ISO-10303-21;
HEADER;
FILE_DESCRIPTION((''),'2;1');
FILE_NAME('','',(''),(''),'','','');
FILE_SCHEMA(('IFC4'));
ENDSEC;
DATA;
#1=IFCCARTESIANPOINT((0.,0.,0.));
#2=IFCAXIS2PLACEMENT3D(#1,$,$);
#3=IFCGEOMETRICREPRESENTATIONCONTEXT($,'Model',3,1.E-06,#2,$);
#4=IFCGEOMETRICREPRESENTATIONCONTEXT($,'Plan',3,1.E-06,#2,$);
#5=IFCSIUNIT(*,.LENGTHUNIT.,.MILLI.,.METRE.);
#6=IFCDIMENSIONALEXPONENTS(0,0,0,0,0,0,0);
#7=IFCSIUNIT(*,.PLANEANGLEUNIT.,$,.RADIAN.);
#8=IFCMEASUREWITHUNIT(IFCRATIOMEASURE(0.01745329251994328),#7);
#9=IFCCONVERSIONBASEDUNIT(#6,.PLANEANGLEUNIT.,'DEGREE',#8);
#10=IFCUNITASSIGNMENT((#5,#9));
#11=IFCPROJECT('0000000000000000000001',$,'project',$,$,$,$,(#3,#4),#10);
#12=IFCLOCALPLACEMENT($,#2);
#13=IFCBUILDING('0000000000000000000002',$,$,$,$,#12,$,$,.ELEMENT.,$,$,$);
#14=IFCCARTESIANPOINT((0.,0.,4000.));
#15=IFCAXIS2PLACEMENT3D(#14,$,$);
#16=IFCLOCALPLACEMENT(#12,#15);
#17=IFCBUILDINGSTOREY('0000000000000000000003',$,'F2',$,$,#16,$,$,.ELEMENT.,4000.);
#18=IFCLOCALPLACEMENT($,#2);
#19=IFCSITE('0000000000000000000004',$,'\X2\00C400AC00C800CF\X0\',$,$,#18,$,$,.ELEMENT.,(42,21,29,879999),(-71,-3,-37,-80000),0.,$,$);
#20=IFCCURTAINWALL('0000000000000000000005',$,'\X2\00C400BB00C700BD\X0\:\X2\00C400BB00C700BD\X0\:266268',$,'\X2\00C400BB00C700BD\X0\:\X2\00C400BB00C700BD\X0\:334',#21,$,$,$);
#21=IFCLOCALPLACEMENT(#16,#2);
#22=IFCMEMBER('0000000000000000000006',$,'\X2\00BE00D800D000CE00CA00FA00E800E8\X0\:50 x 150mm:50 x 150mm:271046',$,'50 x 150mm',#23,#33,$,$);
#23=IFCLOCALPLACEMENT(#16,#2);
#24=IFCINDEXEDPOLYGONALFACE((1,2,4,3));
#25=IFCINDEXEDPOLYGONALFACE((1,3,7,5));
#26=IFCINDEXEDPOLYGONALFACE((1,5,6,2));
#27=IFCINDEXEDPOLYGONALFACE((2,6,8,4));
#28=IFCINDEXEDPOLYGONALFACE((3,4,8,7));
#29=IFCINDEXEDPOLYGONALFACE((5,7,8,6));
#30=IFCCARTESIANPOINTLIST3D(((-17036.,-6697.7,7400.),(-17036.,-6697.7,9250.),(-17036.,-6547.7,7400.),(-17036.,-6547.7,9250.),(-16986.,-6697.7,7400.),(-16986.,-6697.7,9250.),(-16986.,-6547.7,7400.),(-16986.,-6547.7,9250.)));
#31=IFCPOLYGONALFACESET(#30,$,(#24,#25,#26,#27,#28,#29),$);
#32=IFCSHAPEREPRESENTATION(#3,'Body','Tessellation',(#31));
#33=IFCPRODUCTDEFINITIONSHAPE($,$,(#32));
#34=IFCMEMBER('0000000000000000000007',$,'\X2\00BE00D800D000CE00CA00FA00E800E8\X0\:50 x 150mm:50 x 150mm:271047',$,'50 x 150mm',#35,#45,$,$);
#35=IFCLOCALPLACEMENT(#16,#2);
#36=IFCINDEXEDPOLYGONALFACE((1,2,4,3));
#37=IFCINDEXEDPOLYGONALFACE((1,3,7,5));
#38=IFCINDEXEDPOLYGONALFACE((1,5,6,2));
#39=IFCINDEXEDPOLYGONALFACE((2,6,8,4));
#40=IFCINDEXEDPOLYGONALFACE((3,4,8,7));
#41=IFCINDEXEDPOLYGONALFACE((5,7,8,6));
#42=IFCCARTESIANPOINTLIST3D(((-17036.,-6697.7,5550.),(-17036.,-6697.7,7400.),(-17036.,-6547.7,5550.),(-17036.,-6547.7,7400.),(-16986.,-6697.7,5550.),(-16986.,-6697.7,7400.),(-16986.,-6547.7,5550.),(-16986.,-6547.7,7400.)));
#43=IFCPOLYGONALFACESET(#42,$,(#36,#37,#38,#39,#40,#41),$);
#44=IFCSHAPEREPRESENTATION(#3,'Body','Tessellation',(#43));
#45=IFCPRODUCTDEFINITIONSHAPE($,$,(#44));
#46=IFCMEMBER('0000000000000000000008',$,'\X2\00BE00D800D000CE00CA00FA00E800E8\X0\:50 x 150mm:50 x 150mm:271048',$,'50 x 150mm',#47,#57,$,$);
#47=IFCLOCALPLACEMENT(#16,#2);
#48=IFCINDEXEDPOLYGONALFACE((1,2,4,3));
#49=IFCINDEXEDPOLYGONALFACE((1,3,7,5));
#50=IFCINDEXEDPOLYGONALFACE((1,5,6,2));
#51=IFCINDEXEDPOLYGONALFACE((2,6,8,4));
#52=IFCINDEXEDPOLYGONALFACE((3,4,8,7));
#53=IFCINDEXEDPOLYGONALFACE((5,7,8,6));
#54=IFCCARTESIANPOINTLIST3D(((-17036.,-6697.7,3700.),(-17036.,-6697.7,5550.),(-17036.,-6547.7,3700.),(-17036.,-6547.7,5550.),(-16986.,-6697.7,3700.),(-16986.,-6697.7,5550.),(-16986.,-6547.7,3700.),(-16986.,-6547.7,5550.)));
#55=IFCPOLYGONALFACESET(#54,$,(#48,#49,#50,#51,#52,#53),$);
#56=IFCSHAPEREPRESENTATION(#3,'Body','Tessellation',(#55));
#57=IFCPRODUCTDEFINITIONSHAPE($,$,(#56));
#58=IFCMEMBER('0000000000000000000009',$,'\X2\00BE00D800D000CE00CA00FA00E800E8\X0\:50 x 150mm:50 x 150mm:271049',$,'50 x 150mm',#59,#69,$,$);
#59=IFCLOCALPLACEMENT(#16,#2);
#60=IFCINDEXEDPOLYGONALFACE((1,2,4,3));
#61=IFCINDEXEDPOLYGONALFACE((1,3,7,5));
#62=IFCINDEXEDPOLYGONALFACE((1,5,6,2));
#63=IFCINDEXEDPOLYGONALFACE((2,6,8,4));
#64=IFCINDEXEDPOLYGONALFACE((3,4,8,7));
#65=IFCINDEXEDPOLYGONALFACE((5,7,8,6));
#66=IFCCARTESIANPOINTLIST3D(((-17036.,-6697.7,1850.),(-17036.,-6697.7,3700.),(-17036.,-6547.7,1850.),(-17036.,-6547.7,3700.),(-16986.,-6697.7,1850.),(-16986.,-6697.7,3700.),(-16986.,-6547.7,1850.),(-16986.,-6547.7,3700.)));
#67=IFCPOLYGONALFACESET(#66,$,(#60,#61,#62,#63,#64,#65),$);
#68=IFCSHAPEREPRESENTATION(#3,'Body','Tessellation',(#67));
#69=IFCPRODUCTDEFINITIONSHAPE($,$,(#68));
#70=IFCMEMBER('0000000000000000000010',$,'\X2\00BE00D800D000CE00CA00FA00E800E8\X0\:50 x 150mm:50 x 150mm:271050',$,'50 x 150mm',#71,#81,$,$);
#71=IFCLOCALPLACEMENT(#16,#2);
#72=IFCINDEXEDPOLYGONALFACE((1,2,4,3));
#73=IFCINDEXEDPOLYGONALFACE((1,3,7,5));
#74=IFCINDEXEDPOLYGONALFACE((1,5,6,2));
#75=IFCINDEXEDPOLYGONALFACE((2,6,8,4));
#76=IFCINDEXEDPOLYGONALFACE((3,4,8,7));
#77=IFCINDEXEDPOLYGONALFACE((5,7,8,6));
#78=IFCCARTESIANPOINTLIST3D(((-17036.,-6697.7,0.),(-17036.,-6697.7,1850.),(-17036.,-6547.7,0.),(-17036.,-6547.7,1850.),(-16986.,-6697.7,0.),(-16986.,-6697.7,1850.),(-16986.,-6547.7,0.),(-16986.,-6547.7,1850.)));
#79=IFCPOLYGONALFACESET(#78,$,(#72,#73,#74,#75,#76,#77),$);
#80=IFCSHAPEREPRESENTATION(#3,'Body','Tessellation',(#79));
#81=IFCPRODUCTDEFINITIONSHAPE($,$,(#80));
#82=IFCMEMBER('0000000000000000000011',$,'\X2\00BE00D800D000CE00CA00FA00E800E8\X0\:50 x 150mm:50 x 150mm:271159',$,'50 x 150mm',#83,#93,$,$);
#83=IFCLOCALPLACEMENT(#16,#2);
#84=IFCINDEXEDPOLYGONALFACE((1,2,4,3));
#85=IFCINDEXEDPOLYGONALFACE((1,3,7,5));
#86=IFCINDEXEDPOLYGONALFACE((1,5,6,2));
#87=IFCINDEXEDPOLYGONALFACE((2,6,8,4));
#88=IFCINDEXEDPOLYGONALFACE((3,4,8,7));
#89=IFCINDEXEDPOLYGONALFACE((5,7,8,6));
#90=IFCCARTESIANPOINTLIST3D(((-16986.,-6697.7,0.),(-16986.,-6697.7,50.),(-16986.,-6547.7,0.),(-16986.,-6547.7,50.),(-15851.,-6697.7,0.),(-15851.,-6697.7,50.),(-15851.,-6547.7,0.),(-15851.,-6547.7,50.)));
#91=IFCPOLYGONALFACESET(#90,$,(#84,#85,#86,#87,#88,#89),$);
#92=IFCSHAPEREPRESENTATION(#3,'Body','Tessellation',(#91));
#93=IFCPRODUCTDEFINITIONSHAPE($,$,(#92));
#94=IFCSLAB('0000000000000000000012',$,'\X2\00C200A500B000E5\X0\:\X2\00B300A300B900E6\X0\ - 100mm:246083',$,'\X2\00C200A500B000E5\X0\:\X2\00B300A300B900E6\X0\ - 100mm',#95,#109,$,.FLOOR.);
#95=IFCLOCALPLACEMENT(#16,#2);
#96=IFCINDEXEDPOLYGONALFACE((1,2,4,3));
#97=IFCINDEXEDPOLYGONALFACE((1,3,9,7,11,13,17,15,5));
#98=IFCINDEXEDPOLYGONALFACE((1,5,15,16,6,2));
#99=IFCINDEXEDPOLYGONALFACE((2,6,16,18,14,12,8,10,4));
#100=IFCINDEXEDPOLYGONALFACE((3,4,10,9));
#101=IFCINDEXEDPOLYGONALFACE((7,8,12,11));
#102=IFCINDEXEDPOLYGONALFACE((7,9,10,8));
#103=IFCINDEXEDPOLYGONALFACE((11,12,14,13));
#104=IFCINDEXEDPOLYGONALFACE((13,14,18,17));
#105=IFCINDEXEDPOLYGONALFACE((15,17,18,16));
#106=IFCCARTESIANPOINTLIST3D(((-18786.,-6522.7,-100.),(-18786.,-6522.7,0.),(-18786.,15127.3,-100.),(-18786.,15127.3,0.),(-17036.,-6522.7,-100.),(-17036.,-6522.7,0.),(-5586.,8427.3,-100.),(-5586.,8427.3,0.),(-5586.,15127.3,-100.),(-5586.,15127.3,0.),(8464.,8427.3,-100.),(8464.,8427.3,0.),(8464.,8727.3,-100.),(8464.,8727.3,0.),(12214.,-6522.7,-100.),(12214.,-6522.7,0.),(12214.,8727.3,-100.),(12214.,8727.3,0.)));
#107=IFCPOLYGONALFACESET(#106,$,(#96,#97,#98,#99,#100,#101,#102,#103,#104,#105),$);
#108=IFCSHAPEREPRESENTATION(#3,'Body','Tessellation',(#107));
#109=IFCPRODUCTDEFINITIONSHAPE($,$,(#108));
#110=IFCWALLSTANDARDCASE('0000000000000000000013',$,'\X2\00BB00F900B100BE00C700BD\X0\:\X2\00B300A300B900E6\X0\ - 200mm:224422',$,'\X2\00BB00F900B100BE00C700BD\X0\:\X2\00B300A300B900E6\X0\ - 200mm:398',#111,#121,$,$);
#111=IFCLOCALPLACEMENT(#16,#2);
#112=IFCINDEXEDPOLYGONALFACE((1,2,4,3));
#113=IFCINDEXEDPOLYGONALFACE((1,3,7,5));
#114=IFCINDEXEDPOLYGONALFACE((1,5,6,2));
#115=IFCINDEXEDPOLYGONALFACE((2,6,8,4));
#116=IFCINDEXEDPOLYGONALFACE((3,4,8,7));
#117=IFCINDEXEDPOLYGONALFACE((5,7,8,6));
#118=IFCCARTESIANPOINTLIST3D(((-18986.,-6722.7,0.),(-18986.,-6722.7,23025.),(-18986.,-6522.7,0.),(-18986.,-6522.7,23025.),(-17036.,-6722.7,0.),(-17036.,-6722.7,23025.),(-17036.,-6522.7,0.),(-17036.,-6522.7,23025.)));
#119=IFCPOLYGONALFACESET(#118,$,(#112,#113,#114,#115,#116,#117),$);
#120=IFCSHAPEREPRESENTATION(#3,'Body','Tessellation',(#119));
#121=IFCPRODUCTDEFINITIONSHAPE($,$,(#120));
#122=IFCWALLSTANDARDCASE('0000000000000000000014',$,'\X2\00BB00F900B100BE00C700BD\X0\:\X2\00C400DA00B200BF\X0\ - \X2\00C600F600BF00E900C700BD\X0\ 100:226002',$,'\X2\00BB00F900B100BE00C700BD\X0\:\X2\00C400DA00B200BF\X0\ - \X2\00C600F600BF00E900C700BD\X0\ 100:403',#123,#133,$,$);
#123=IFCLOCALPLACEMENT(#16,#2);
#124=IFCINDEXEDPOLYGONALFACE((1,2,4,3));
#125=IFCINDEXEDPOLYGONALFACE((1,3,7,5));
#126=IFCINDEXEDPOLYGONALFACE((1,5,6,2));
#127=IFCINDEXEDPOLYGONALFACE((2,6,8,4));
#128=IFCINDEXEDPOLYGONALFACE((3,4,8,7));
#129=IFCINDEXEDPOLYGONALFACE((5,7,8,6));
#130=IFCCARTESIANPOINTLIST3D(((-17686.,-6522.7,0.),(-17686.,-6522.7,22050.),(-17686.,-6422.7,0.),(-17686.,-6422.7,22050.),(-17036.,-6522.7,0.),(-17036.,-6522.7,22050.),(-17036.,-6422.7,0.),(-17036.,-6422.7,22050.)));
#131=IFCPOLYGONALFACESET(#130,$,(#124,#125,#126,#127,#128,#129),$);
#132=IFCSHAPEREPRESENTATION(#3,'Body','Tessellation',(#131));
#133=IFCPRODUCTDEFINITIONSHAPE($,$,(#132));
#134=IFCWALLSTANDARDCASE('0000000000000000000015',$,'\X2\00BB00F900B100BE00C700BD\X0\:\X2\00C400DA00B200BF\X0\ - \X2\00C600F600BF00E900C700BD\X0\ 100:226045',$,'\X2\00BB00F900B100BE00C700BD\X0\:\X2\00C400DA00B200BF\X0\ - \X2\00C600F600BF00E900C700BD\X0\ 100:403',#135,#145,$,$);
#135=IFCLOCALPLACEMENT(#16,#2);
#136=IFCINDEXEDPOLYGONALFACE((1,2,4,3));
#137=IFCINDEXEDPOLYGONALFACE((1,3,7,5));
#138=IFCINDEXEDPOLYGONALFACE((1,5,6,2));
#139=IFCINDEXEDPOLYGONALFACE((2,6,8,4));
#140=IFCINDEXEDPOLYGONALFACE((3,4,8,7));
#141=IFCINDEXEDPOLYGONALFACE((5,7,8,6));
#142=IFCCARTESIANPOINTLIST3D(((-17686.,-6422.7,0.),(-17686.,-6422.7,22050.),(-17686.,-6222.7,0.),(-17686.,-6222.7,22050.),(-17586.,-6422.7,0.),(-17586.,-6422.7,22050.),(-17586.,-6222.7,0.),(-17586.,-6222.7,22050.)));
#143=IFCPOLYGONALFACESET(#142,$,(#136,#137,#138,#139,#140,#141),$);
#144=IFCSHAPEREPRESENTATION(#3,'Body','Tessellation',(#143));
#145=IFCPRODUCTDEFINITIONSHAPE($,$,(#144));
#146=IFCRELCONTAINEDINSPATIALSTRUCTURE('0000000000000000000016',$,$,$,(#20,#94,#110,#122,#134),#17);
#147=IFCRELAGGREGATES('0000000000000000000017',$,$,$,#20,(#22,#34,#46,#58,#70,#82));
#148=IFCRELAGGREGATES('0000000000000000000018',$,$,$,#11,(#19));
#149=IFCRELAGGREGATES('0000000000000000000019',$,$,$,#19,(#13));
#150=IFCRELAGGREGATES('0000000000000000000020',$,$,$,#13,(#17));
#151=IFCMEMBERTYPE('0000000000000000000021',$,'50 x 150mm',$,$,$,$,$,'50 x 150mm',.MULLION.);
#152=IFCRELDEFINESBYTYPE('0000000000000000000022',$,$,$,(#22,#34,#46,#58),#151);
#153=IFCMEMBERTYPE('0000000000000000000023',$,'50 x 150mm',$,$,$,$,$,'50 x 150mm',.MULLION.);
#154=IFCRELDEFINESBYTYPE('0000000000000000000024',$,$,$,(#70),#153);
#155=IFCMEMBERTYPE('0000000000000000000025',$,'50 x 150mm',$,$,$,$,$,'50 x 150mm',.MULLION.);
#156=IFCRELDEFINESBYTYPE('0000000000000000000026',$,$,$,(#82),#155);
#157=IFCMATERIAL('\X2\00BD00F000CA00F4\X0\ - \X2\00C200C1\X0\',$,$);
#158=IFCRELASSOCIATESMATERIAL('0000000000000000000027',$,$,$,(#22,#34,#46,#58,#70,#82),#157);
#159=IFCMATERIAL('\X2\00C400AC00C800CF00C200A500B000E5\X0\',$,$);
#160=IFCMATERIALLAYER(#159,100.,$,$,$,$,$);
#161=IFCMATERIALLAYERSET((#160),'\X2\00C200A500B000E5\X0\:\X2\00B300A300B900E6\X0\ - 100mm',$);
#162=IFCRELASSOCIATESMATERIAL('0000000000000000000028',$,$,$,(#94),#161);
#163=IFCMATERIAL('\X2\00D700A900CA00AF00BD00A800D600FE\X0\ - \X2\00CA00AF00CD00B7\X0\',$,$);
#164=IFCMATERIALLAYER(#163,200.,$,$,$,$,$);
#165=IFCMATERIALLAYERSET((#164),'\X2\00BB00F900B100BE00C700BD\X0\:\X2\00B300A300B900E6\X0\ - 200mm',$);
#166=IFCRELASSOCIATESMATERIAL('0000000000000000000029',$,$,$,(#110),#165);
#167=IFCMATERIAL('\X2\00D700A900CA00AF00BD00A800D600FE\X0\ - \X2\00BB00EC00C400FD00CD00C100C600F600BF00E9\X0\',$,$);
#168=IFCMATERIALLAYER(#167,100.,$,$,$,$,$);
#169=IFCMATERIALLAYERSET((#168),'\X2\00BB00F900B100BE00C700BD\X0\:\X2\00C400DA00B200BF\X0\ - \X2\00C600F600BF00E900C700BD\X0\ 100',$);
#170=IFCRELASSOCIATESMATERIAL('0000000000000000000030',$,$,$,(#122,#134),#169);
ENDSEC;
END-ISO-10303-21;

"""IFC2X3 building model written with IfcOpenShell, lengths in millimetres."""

from ifc_helpers import new_model, entity, si_unit, converted_unit, frame, frame_2d, origin, origin_2d_with_axis, place, context, project, spatial, polyline, rectangle, outline, extrude, clip, bounded_halfspace, source, transform, mapped, material, layer, layer_set, layer_usage, type_object, type_shapes, element, aggregate, save


model = new_model("IFC2X3")

# Units and contexts
model_context = context("Model", 3, precision=1e-06, world=origin())
plan_context = context("Plan", 3, precision=1e-06, world=origin())
ifc_project = project(units=[si_unit("LENGTHUNIT", "METRE", prefix="MILLI"), converted_unit("PLANEANGLEUNIT", "DEGREE", entity("IfcRatioMeasure", 0.01745329251994328), si_unit("PLANEANGLEUNIT", "RADIAN"), dimensions=[0, 0, 0, 0, 0, 0, 0])], contexts=[model_context, plan_context])

# Site, building, storey
site_placement = place(None, origin())
site = spatial("IfcSite", under=ifc_project, at=site_placement, Name="Ä¬ÈÏ", CompositionType="ELEMENT", RefLatitude=(42, 21, 29, 879999), RefLongitude=(-71, -3, -37, -80000), RefElevation=0.0)
building_placement = place(None, origin())
building = spatial("IfcBuilding", under=site, at=building_placement, CompositionType="ELEMENT")
storey_placement = place(building_placement, frame((0.0, 0.0, 4000.0)))
storey = spatial("IfcBuildingStorey", under=building, at=storey_placement, Name="F2", CompositionType="ELEMENT", Elevation=4000.0)

# Curtain wall, members
curtain_wall_placement = place(storey_placement, origin())
curtain_wall = element("IfcCurtainWall", 1, at=curtain_wall_placement, inside=storey, Name="Ä»Ç½:Ä»Ç½:266268", ObjectType="Ä»Ç½:Ä»Ç½:334")
ifc_material_1 = material(Name="½ðÊô - ÂÁ")
member_type_1 = type_object("IfcMemberType", Name="50 x 150mm", ElementType="50 x 150mm", PredefinedType="MULLION")
shared_shape_1 = source(origin(), model_context, "Body", "SweptSolid", [
    extrude(rectangle(XDim=50.0, YDim=150.0, at=origin_2d_with_axis()), frame((-25.0, 0.0, -1850.0), z_axis=(0.0, 0.0, 1.0), x_axis=(-1.0, 0.0, 0.0)), (0.0, 0.0, 1.0), 1850.0),
])
type_shapes(member_type_1, [shared_shape_1])
placement_1 = place(building_placement, frame((0.0, 0.0, 11400.0)))
member_1_placement = place(placement_1, frame((-17036.0, -6622.7, 1850.0), z_axis=(0.0, 0.0, 1.0), x_axis=(-1.0, 0.0, 0.0)))
member_1 = element("IfcMember", 2, at=member_1_placement, type_object=member_type_1, material=ifc_material_1, Name="¾ØÐÎÊúèè:50 x 150mm:50 x 150mm:271046", ObjectType="50 x 150mm", context=model_context, shape_type="MappedRepresentation", body=[
    mapped(shared_shape_1, transform((0.0, 0.0, 0.0), scale=1.0)),
])
placement_2 = place(building_placement, frame((0.0, 0.0, 7700.0)))
member_2_placement = place(placement_2, frame((-17036.0, -6622.7, 3700.0), z_axis=(0.0, 0.0, 1.0), x_axis=(-1.0, 0.0, 0.0)))
member_2 = element("IfcMember", 3, at=member_2_placement, type_object=member_type_1, material=ifc_material_1, Name="¾ØÐÎÊúèè:50 x 150mm:50 x 150mm:271047", ObjectType="50 x 150mm", context=model_context, shape_type="MappedRepresentation", body=[
    mapped(shared_shape_1, transform((0.0, 0.0, 0.0), scale=1.0)),
])
member_3_placement = place(placement_2, frame((-17036.0, -6622.7, 1850.0), z_axis=(0.0, 0.0, 1.0), x_axis=(-1.0, 0.0, 0.0)))
member_3 = element("IfcMember", 4, at=member_3_placement, type_object=member_type_1, material=ifc_material_1, Name="¾ØÐÎÊúèè:50 x 150mm:50 x 150mm:271048", ObjectType="50 x 150mm", context=model_context, shape_type="MappedRepresentation", body=[
    mapped(shared_shape_1, transform((0.0, 0.0, 0.0), scale=1.0)),
])
member_4_placement = place(storey_placement, frame((-17036.0, -6622.7, 3700.0), z_axis=(0.0, 0.0, 1.0), x_axis=(-1.0, 0.0, 0.0)))
member_4 = element("IfcMember", 5, at=member_4_placement, type_object=member_type_1, material=ifc_material_1, Name="¾ØÐÎÊúèè:50 x 150mm:50 x 150mm:271049", ObjectType="50 x 150mm", context=model_context, shape_type="MappedRepresentation", body=[
    mapped(shared_shape_1, transform((0.0, 0.0, 0.0), scale=1.0)),
])
member_type_2 = type_object("IfcMemberType", Name="50 x 150mm", ElementType="50 x 150mm", PredefinedType="MULLION")
shared_shape_2 = source(origin(), model_context, "Body", "SweptSolid", [
    extrude(rectangle(XDim=50.0, YDim=150.0, at=origin_2d_with_axis()), frame((-25.0, 0.0, -1850.0), z_axis=(0.0, 0.0, 1.0), x_axis=(-1.0, 0.0, 0.0)), (0.0, 0.0, 1.0), 1850.0),
])
type_shapes(member_type_2, [shared_shape_2])
member_5_placement = place(storey_placement, frame((-17036.0, -6622.7, 1850.0), z_axis=(0.0, 0.0, 1.0), x_axis=(-1.0, 0.0, 0.0)))
member_5 = element("IfcMember", 6, at=member_5_placement, type_object=member_type_2, material=ifc_material_1, Name="¾ØÐÎÊúèè:50 x 150mm:50 x 150mm:271050", ObjectType="50 x 150mm", context=model_context, shape_type="MappedRepresentation", body=[
    mapped(shared_shape_2, transform((0.0, 0.0, 0.0), scale=1.0)),
])
member_type_3 = type_object("IfcMemberType", Name="50 x 150mm", ElementType="50 x 150mm", PredefinedType="MULLION")
shared_shape_3 = source(origin(), model_context, "Body", "SweptSolid", [
    extrude(rectangle(XDim=50.0, YDim=150.0, at=origin_2d_with_axis()), frame((-25.0, 0.0, -1135.0), z_axis=(0.0, 0.0, 1.0), x_axis=(-1.0, 0.0, 0.0)), (0.0, 0.0, 1.0), 1135.0),
])
type_shapes(member_type_3, [shared_shape_3])
member_6_placement = place(storey_placement, frame((-16986.0, -6622.7, 0.0), z_axis=(-1.0, 0.0, 0.0), x_axis=(0.0, 0.0, -1.0)))
member_6 = element("IfcMember", 7, at=member_6_placement, type_object=member_type_3, material=ifc_material_1, Name="¾ØÐÎÊúèè:50 x 150mm:50 x 150mm:271159", ObjectType="50 x 150mm", context=model_context, shape_type="MappedRepresentation", body=[
    mapped(shared_shape_3, transform((0.0, 0.0, 0.0), scale=1.0)),
])
aggregate(curtain_wall, [member_1, member_2, member_3, member_4, member_5, member_6])

# Slab
ifc_material_2 = material(Name="Ä¬ÈÏÂ¥°å")
ifc_layer_1 = layer(ifc_material_2, 100.0)
ifc_layer_set_1 = layer_set([ifc_layer_1], Name="Â¥°å:³£¹æ - 100mm")
ifc_layer_usage_1 = layer_usage(ifc_layer_set_1, "AXIS3", "POSITIVE", 0.0)
slab_placement = place(storey_placement, frame((-18786.0, -6522.7, -100.0)))
element("IfcSlab", 8, at=slab_placement, inside=storey, material=ifc_layer_usage_1, Name="Â¥°å:³£¹æ - 100mm:246083", ObjectType="Â¥°å:³£¹æ - 100mm", PredefinedType="FLOOR", context=model_context, shape_type="SweptSolid", body=[
    extrude(outline(polyline([(18786.0, -6522.7), (18786.0, 15127.3), (5586.0, 15127.3), (5586.0, 8427.3), (-8464.0, 8427.3), (-8464.0, 8727.3), (-12214.0, 8727.3), (-12214.0, -6522.7), (17036.0, -6522.7), (18786.0, -6522.7)])), frame((18786.0, 6522.7, 100.0), z_axis=(0.0, 0.0, -1.0), x_axis=(-1.0, 0.0, 0.0)), (0.0, 0.0, 1.0), 100.0),
])

# Walls
ifc_material_3 = material(Name="×©Ê¯½¨Öþ - Ê¯Í·")
ifc_layer_2 = layer(ifc_material_3, 200.0)
ifc_layer_set_2 = layer_set([ifc_layer_2], Name="»ù±¾Ç½:³£¹æ - 200mm")
ifc_layer_usage_2 = layer_usage(ifc_layer_set_2, "AXIS2", "NEGATIVE", 100.0)
wall_1_placement = place(storey_placement, frame((-17036.0, -6622.7, 0.0), z_axis=(0.0, 0.0, 1.0), x_axis=(-1.0, 0.0, 0.0)))
element("IfcWallStandardCase", 9, at=wall_1_placement, inside=storey, material=ifc_layer_usage_2, Name="»ù±¾Ç½:³£¹æ - 200mm:224422", ObjectType="»ù±¾Ç½:³£¹æ - 200mm:398", context=model_context, shape_type="SweptSolid", body=[
    extrude(rectangle(XDim=1950.0, YDim=200.0, at=frame_2d((975.0, 0.0), x_axis=(-1.0, 0.0))), origin(), (0.0, 0.0, 1.0), 23025.0),
])
ifc_material_4 = material(Name="×©Ê¯½¨Öþ - »ìÄýÍÁÆö¿é")
ifc_layer_3 = layer(ifc_material_4, 100.0)
ifc_layer_set_3 = layer_set([ifc_layer_3], Name="»ù±¾Ç½:ÄÚ²¿ - Æö¿éÇ½ 100")
ifc_layer_usage_3 = layer_usage(ifc_layer_set_3, "AXIS2", "NEGATIVE", 50.0)
wall_2_placement = place(storey_placement, frame((-17036.0, -6472.7, 0.0), z_axis=(0.0, 0.0, 1.0), x_axis=(-1.0, 0.0, 0.0)))
element("IfcWallStandardCase", 10, at=wall_2_placement, inside=storey, material=ifc_layer_usage_3, Name="»ù±¾Ç½:ÄÚ²¿ - Æö¿éÇ½ 100:226002", ObjectType="»ù±¾Ç½:ÄÚ²¿ - Æö¿éÇ½ 100:403", context=model_context, shape_type="Clipping", body=[
    clip(extrude(rectangle(XDim=650.0, YDim=100.0, at=frame_2d((325.0, 0.0), x_axis=(-1.0, 0.0))), origin(), (0.0, 0.0, 1.0), 22050.0), bounded_halfspace(frame((0.0, -50.0, 22050.0), z_axis=(0.0, 0.0, -1.0), x_axis=(-1.0, 0.0, 0.0)), True, frame((0.0, -50.0, 22050.0)), polyline([(0.0, 0.0), (550.0, 0.0), (650.0, 0.0), (650.0, 100.0), (0.0, 100.0), (0.0, 0.0)]))),
])
ifc_layer_usage_4 = layer_usage(ifc_layer_set_3, "AXIS2", "NEGATIVE", 50.0)
wall_3_placement = place(storey_placement, frame((-17636.0, -6422.7, 0.0), z_axis=(0.0, 0.0, 1.0), x_axis=(0.0, 1.0, 0.0)))
element("IfcWallStandardCase", 11, at=wall_3_placement, inside=storey, material=ifc_layer_usage_4, Name="»ù±¾Ç½:ÄÚ²¿ - Æö¿éÇ½ 100:226045", ObjectType="»ù±¾Ç½:ÄÚ²¿ - Æö¿éÇ½ 100:403", context=model_context, shape_type="Clipping", body=[
    clip(extrude(rectangle(XDim=200.0, YDim=100.0, at=frame_2d((100.0, 0.0), x_axis=(-1.0, 0.0))), origin(), (0.0, 0.0, 1.0), 22050.0), bounded_halfspace(frame((0.0, -50.0, 22050.0), z_axis=(0.0, 0.0, -1.0), x_axis=(0.0, -1.0, 0.0)), True, frame((0.0, -50.0, 22050.0)), polyline([(0.0, 0.0), (200.0, 0.0), (200.0, 100.0), (0.0, 100.0), (0.0, 0.0)]))),
])

save(model, "model.ifc")
